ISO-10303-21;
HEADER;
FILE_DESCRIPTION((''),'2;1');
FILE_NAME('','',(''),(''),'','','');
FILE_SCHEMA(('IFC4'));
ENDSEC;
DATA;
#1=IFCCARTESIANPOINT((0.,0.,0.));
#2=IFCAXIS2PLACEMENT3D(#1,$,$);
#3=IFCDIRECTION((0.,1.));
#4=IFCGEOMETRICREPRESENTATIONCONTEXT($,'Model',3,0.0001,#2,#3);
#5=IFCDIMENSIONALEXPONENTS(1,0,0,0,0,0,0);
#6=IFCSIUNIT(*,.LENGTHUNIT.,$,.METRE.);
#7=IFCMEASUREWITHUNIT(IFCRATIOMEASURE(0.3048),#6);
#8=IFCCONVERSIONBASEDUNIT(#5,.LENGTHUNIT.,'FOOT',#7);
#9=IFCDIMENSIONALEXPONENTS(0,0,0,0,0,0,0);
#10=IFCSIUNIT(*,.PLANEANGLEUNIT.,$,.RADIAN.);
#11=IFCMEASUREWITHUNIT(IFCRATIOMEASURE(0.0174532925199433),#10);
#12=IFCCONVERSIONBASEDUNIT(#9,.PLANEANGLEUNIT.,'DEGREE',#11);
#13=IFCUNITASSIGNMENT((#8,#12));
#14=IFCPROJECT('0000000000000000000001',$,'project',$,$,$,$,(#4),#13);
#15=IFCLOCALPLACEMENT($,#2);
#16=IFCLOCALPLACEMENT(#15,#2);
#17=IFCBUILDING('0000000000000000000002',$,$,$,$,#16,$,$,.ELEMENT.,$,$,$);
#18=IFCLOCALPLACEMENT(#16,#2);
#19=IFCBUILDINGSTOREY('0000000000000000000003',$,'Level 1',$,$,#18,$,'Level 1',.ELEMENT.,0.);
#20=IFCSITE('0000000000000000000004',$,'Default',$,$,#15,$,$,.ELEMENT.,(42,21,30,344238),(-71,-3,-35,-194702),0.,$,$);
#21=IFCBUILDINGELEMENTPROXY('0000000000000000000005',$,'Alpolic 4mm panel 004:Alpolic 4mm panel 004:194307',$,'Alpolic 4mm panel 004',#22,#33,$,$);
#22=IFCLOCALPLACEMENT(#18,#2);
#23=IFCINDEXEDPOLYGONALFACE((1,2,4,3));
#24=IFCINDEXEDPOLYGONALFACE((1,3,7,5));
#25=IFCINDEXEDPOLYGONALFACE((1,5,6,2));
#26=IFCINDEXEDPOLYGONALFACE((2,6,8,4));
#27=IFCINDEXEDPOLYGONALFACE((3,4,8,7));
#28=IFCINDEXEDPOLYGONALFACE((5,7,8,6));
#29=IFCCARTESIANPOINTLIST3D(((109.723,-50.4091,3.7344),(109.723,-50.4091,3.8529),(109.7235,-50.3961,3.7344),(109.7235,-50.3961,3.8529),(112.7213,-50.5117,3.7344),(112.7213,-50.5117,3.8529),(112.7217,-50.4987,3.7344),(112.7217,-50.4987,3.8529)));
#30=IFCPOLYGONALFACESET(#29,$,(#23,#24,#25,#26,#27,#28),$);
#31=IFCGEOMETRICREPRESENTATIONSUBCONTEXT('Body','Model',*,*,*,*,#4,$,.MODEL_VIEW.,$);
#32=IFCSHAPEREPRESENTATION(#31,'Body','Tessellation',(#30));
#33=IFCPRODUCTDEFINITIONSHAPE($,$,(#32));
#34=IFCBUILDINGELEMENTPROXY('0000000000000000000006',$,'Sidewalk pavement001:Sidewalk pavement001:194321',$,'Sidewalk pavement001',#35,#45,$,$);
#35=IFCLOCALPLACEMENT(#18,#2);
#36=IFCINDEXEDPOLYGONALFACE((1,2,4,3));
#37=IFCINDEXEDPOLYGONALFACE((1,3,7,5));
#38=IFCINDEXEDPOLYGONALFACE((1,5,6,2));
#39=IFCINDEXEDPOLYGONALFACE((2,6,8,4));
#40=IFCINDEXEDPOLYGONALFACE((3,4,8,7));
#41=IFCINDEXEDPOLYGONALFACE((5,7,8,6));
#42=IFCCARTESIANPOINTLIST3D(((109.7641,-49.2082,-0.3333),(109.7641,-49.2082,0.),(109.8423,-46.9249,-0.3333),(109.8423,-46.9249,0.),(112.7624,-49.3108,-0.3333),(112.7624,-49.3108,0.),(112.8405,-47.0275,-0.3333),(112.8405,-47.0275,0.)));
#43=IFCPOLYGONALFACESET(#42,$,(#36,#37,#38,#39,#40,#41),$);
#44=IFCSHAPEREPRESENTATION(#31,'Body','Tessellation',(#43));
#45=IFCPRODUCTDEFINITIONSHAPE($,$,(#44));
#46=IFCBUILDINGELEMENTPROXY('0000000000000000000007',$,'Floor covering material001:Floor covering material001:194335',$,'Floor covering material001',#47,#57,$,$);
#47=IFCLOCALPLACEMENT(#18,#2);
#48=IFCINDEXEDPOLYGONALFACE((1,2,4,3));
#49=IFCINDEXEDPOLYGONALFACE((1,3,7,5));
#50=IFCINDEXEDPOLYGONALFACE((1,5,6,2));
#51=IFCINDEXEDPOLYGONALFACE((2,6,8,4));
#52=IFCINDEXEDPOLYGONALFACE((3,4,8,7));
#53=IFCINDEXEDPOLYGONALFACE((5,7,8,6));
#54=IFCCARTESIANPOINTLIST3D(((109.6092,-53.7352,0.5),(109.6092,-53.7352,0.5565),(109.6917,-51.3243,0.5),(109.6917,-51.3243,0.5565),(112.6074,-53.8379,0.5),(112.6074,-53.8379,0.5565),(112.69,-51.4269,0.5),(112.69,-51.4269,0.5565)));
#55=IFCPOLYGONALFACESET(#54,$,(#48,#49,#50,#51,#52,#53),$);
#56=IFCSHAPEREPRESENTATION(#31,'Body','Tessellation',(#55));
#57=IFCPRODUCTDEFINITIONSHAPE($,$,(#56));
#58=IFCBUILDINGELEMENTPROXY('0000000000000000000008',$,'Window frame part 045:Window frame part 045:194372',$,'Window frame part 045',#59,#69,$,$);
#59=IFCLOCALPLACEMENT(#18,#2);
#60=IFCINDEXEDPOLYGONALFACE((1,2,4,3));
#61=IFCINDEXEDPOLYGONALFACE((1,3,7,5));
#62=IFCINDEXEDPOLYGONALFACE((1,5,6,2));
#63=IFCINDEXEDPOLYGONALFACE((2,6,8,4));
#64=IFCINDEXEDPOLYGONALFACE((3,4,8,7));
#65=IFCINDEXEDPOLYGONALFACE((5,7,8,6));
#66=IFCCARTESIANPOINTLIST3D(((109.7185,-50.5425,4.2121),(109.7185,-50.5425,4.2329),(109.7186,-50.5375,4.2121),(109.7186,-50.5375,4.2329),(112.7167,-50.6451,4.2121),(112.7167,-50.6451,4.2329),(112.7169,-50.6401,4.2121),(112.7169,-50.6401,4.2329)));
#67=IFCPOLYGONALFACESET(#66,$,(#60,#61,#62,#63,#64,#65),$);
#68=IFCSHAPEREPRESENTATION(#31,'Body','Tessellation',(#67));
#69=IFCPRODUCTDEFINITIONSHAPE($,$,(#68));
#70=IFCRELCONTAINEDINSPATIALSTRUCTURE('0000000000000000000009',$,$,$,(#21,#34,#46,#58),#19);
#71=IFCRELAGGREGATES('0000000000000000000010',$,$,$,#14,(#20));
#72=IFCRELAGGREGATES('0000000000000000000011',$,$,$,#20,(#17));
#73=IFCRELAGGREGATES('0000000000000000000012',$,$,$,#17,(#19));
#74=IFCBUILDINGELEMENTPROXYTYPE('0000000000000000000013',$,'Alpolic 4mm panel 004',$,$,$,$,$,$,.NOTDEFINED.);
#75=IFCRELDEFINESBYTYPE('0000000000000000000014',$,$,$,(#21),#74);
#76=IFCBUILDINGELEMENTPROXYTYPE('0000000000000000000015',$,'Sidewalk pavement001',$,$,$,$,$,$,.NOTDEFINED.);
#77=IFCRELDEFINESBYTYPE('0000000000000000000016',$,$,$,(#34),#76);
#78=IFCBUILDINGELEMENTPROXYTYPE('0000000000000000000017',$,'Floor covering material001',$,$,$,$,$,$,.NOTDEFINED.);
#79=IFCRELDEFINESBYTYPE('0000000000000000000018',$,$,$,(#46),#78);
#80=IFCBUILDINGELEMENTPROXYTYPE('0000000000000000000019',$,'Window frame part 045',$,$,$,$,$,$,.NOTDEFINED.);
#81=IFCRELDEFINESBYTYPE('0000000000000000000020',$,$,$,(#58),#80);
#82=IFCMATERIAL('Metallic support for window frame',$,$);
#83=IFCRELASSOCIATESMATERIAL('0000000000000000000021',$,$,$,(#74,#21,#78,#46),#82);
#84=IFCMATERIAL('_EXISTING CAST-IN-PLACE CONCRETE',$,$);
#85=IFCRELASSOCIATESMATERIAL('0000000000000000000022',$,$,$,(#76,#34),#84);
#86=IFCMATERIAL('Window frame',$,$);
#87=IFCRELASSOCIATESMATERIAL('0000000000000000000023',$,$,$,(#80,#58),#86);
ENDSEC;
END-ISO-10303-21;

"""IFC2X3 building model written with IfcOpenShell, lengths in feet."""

from ifc_helpers import new_model, entity, si_unit, converted_unit, direction, frame, frame_2d, origin, origin_2d_with_axis, place, context, subcontext, project, spatial, rectangle, extrude, source, transform, mapped, material, type_object, type_shapes, element, save


model = new_model("IFC2X3")

# Units and contexts
model_context = context("Model", 3, precision=0.0001, world=origin(), true_north=direction((0.0, 1.0)))
body_context = subcontext(model_context, "Body", "Model", "MODEL_VIEW")
ifc_project = project(units=[converted_unit("LENGTHUNIT", "FOOT", entity("IfcRatioMeasure", 0.3048), si_unit("LENGTHUNIT", "METRE"), dimensions=[1, 0, 0, 0, 0, 0, 0]), converted_unit("PLANEANGLEUNIT", "DEGREE", entity("IfcRatioMeasure", 0.0174532925199433), si_unit("PLANEANGLEUNIT", "RADIAN"), dimensions=[0, 0, 0, 0, 0, 0, 0])], contexts=[model_context])

# Site, building, storey
site_placement = place(None, origin())
site = spatial("IfcSite", under=ifc_project, at=site_placement, Name="Default", CompositionType="ELEMENT", RefLatitude=(42, 21, 30, 344238), RefLongitude=(-71, -3, -35, -194702), RefElevation=0.0)
building_placement = place(site_placement, origin())
building = spatial("IfcBuilding", under=site, at=building_placement, CompositionType="ELEMENT")
storey_placement = place(building_placement, origin())
storey = spatial("IfcBuildingStorey", under=building, at=storey_placement, Name="Level 1", LongName="Level 1", CompositionType="ELEMENT", Elevation=0.0)

# Building element proxies
ifc_material_1 = material(Name="_EXISTING CAST-IN-PLACE CONCRETE")
ifc_material_2 = material(Name="Window frame")
ifc_material_3 = material(Name="Metallic support for window frame")
building_element_proxy_type_1 = type_object("IfcBuildingElementProxyType", Name="Alpolic 4mm panel 004", PredefinedType="NOTDEFINED", material=ifc_material_3)
shared_shape_1 = source(origin(), body_context, "Body", "SweptSolid", [
    extrude(rectangle(XDim=3.0, YDim=0.013, at=origin_2d_with_axis()), frame((111.2224, -50.4539, 3.7344), z_axis=(0.0, 0.0, 1.0), x_axis=(0.999415, -0.034202, 0.0)), (0.0, 0.0, 1.0), 0.1185),
])
type_shapes(building_element_proxy_type_1, [shared_shape_1])
proxy_1_placement = place(storey_placement, origin())
element("IfcBuildingElementProxy", 1, at=proxy_1_placement, inside=storey, type_object=building_element_proxy_type_1, material=ifc_material_3, Name="Alpolic 4mm panel 004:Alpolic 4mm panel 004:194307", ObjectType="Alpolic 4mm panel 004", context=body_context, shape_type="MappedRepresentation", body=[
    mapped(shared_shape_1, transform((0.0, 0.0, 0.0), scale=1.0)),
])
building_element_proxy_type_2 = type_object("IfcBuildingElementProxyType", Name="Sidewalk pavement001", PredefinedType="NOTDEFINED", material=ifc_material_1)
shared_shape_2 = source(origin(), body_context, "Body", "SweptSolid", [
    extrude(rectangle(XDim=3.0, YDim=2.2847, at=origin_2d_with_axis()), frame((111.3023, -48.1179, -0.3333), z_axis=(0.0, 0.0, 1.0), x_axis=(0.999415, -0.034202, 0.0)), (0.0, 0.0, 1.0), 0.3333),
])
type_shapes(building_element_proxy_type_2, [shared_shape_2])
proxy_2_placement = place(storey_placement, origin())
element("IfcBuildingElementProxy", 2, at=proxy_2_placement, inside=storey, type_object=building_element_proxy_type_2, material=ifc_material_1, Name="Sidewalk pavement001:Sidewalk pavement001:194321", ObjectType="Sidewalk pavement001", context=body_context, shape_type="MappedRepresentation", body=[
    mapped(shared_shape_2, transform((0.0, 0.0, 0.0), scale=1.0)),
])
building_element_proxy_type_3 = type_object("IfcBuildingElementProxyType", Name="Floor covering material001", PredefinedType="NOTDEFINED", material=ifc_material_3)
shared_shape_3 = source(origin(), body_context, "Body", "SweptSolid", [
    extrude(rectangle(XDim=3.0, YDim=2.4124, at=origin_2d_with_axis()), frame((111.1496, -52.5811, 0.5), z_axis=(0.0, 0.0, 1.0), x_axis=(0.999415, -0.034202, 0.0)), (0.0, 0.0, 1.0), 0.0565),
])
type_shapes(building_element_proxy_type_3, [shared_shape_3])
proxy_3_placement = place(storey_placement, origin())
element("IfcBuildingElementProxy", 3, at=proxy_3_placement, inside=storey, type_object=building_element_proxy_type_3, material=ifc_material_3, Name="Floor covering material001:Floor covering material001:194335", ObjectType="Floor covering material001", context=body_context, shape_type="MappedRepresentation", body=[
    mapped(shared_shape_3, transform((0.0, 0.0, 0.0), scale=1.0)),
])
building_element_proxy_type_4 = type_object("IfcBuildingElementProxyType", Name="Window frame part 045", PredefinedType="NOTDEFINED", material=ifc_material_2)
shared_shape_4 = source(origin(), body_context, "Body", "SweptSolid", [
    extrude(rectangle(XDim=3.0, YDim=0.005, at=frame_2d((0.0, 0.0), x_axis=(1.0, 0.0))), frame((111.2177, -50.5913, 4.2121), z_axis=(0.0, 0.0, 1.0), x_axis=(0.999415, -0.034202, 0.0)), (0.0, 0.0, 1.0), 0.0208),
])
type_shapes(building_element_proxy_type_4, [shared_shape_4])
proxy_4_placement = place(storey_placement, origin())
element("IfcBuildingElementProxy", 4, at=proxy_4_placement, inside=storey, type_object=building_element_proxy_type_4, material=ifc_material_2, Name="Window frame part 045:Window frame part 045:194372", ObjectType="Window frame part 045", context=body_context, shape_type="MappedRepresentation", body=[
    mapped(shared_shape_4, transform((0.0, 0.0, 0.0), scale=1.0)),
])

save(model, "model.ifc")
